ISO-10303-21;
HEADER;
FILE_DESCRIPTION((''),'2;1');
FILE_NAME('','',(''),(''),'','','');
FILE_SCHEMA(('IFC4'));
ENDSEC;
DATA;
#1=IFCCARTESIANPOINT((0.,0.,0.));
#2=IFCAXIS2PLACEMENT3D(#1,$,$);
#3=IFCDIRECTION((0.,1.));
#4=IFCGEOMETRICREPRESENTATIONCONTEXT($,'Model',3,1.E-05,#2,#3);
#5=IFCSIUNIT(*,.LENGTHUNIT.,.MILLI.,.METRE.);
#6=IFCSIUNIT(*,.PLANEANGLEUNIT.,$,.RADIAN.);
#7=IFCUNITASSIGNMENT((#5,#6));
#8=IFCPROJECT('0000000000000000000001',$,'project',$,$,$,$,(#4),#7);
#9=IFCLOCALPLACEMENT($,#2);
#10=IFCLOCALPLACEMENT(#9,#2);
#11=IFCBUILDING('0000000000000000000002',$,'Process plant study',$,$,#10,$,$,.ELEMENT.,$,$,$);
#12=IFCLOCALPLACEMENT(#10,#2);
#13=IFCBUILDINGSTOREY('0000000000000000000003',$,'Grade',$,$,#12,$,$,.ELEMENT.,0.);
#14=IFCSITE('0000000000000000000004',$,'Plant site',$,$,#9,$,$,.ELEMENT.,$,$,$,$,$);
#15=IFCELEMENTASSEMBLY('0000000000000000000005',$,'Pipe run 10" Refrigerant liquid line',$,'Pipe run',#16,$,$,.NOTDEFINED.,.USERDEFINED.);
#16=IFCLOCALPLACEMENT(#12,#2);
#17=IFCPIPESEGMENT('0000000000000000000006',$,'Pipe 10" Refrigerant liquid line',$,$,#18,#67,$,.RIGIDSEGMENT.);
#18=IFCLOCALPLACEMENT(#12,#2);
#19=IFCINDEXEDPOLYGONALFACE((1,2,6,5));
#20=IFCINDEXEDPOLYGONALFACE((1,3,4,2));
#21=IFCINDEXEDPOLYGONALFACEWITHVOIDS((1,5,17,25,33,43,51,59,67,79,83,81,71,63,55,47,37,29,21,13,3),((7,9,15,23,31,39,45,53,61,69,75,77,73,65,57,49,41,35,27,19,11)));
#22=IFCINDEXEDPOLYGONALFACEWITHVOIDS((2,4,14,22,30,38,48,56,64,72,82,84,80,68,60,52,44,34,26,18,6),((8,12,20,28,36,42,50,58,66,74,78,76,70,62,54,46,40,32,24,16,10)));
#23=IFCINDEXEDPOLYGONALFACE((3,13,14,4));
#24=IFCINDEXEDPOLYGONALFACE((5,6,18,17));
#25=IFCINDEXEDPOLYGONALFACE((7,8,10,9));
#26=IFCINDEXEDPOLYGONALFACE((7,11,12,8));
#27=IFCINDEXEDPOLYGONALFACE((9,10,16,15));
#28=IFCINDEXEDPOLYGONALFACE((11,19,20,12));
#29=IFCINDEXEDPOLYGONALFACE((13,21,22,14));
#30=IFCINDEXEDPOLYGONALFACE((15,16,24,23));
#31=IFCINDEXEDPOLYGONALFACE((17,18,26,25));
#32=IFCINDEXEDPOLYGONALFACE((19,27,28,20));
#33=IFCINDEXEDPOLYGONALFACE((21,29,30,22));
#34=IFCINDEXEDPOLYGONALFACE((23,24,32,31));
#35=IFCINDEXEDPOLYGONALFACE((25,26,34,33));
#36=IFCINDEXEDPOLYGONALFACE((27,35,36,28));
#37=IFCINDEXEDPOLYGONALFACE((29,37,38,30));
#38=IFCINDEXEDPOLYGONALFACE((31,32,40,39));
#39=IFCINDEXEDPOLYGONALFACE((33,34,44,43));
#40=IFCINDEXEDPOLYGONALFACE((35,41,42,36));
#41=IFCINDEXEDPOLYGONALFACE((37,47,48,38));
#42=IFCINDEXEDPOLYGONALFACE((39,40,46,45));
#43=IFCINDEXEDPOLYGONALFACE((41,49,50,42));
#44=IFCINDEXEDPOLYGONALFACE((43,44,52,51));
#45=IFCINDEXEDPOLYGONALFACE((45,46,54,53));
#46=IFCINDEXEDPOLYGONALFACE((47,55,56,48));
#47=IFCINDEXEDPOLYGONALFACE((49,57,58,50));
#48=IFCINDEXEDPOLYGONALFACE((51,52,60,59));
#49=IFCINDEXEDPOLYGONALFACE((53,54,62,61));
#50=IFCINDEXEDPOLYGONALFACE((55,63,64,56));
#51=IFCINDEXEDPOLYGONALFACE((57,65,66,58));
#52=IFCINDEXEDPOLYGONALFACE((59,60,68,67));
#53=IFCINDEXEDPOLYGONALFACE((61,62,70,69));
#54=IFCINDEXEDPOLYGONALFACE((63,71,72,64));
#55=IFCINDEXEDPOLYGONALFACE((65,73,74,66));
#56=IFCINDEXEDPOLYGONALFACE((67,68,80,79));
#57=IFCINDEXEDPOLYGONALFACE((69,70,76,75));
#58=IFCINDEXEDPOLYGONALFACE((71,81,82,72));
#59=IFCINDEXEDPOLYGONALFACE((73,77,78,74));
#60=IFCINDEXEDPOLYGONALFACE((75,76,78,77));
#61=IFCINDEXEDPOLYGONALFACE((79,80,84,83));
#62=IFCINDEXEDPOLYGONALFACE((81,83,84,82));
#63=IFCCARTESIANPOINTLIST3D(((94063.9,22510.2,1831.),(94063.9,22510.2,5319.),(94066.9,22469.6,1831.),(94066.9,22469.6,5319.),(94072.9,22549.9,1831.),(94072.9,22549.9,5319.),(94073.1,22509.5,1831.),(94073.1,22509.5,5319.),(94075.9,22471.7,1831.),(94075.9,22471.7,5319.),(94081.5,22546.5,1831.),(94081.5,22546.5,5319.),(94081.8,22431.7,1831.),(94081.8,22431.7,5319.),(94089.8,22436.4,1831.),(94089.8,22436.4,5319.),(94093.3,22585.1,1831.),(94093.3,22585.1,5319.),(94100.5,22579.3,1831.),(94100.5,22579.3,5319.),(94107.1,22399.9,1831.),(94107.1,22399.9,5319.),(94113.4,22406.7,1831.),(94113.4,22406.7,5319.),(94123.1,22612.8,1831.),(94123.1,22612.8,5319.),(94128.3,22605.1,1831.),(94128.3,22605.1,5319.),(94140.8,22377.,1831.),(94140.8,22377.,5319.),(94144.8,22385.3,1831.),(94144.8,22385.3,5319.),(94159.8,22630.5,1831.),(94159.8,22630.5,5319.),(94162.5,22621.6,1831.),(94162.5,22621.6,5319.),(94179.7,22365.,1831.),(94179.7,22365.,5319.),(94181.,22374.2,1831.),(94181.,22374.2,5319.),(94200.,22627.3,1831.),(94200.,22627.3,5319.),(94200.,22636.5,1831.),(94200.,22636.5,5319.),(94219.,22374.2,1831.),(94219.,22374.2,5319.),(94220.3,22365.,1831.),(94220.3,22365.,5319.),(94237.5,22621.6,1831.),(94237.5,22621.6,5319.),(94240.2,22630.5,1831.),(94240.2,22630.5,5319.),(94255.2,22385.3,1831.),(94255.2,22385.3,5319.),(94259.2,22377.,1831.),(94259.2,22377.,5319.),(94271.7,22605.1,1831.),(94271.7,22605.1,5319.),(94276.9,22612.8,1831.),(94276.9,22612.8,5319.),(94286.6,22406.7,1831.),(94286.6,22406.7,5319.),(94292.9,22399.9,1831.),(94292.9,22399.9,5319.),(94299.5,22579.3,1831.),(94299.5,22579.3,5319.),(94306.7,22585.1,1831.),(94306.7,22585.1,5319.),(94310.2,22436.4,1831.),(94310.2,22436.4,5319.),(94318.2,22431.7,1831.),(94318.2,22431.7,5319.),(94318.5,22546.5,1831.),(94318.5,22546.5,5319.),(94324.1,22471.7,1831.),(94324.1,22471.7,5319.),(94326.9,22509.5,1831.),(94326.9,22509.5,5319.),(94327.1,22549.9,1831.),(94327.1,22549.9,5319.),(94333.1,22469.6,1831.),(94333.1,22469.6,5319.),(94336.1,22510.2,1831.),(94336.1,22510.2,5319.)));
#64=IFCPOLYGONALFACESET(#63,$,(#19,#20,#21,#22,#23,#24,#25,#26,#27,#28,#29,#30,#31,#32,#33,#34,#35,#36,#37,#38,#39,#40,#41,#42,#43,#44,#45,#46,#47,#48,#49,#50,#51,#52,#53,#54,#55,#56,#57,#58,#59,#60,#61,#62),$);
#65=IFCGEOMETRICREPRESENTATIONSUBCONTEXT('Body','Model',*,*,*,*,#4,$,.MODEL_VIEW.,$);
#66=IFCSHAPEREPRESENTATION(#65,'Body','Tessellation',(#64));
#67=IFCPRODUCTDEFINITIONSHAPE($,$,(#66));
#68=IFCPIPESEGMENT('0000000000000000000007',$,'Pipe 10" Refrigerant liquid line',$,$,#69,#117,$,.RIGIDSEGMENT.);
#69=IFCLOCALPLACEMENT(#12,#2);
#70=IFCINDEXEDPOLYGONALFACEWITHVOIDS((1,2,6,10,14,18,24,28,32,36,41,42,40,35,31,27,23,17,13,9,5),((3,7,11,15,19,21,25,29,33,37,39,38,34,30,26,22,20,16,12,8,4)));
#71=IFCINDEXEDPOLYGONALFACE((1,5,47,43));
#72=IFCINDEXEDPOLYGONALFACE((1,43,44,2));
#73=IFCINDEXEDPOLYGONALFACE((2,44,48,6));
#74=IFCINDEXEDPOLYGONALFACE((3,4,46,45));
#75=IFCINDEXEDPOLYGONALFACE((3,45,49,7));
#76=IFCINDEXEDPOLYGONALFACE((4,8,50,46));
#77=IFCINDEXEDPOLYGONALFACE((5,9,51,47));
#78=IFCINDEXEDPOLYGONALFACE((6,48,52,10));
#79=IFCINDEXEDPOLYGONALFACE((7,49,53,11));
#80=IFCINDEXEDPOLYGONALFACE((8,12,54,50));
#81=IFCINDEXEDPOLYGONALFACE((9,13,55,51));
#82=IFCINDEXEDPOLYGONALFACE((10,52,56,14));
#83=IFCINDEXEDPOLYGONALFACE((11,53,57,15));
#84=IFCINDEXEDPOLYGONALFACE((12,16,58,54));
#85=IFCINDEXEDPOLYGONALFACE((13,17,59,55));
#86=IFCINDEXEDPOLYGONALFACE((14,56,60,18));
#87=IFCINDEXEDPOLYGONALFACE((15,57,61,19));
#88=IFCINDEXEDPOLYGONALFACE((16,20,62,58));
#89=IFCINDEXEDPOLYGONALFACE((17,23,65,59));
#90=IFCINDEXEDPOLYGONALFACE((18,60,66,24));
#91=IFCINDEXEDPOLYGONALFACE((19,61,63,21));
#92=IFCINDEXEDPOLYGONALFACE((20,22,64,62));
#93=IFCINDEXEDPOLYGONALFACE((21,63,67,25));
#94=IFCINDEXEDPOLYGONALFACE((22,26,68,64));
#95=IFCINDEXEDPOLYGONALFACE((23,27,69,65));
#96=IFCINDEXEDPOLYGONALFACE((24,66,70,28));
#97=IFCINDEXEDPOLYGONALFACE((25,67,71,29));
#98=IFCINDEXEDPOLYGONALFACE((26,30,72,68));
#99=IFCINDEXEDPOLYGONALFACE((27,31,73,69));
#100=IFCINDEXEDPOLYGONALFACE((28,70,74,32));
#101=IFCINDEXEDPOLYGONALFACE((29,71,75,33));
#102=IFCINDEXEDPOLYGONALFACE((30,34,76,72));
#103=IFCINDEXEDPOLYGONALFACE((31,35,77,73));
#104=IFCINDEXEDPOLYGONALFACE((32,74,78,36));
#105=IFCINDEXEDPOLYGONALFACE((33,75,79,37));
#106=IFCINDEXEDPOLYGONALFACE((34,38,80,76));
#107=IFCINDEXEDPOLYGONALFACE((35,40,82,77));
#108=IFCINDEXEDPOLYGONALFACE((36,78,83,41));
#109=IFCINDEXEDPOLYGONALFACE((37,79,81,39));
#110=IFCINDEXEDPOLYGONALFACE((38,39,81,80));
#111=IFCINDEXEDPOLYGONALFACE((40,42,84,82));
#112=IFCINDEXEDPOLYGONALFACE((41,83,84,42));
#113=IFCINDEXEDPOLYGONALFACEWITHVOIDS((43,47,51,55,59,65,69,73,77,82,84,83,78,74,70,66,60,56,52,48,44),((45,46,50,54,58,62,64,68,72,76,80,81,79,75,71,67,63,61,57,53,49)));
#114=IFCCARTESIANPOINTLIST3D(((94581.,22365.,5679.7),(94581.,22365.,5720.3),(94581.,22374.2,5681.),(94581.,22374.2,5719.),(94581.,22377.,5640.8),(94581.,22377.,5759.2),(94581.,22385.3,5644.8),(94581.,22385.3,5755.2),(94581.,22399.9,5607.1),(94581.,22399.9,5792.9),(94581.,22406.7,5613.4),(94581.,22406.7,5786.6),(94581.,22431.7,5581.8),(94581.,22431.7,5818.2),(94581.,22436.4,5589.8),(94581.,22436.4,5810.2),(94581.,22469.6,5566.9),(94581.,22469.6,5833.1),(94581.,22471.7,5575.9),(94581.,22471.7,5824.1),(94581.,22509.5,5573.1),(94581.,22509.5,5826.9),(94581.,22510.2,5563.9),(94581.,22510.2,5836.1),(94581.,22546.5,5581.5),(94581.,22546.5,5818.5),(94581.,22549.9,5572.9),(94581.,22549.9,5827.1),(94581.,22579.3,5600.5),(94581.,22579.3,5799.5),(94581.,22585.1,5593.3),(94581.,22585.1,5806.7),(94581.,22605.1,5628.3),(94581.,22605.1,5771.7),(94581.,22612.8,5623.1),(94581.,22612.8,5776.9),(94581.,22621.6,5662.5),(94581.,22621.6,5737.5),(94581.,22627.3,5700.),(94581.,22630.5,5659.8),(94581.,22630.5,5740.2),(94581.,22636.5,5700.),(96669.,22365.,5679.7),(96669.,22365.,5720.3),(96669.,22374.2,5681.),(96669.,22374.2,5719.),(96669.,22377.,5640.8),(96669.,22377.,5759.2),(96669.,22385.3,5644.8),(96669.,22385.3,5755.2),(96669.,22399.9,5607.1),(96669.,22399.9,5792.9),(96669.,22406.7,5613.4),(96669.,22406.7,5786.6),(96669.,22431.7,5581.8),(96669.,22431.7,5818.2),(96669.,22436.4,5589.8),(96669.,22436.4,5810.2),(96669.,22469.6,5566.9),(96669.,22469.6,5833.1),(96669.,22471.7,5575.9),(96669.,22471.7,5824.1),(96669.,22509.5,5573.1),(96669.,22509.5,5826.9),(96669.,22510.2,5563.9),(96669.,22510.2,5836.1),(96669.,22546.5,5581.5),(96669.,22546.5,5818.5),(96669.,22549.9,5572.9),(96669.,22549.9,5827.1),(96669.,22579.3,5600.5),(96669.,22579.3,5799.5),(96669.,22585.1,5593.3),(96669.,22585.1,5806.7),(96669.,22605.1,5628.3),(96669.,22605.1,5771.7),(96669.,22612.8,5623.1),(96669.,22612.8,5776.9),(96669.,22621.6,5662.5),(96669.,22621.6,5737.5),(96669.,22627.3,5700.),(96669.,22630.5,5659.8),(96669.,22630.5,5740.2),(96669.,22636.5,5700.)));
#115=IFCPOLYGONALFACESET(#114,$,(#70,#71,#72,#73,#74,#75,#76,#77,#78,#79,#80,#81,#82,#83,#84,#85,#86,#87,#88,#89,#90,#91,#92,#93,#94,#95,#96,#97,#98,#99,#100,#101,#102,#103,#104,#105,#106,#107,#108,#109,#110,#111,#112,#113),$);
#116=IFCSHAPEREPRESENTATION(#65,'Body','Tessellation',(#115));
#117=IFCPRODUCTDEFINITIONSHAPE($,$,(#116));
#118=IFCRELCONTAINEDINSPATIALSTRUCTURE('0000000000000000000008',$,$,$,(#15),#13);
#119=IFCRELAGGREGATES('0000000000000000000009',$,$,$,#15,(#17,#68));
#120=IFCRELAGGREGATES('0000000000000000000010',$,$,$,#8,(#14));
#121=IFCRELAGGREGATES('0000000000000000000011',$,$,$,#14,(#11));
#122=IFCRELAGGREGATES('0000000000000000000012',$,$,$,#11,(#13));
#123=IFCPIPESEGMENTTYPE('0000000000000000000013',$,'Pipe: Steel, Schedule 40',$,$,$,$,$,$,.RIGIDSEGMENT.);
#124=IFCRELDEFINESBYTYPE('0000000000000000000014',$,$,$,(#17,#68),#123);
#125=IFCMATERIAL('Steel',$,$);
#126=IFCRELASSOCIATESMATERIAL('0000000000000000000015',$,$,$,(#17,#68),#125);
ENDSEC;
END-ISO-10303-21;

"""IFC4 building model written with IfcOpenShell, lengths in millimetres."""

from ifc_helpers import new_model, si_unit, direction, frame, origin, origin_with_axes, origin_2d, place, context, subcontext, project, spatial, hollow_circle, extrude, material, type_object, element, aggregate, save


model = new_model("IFC4")

# Units and contexts
model_context = context("Model", 3, precision=1e-05, world=origin(), true_north=direction((0.0, 1.0)))
body_context = subcontext(model_context, "Body", "Model", "MODEL_VIEW")
ifc_project = project(units=[si_unit("LENGTHUNIT", "METRE", prefix="MILLI"), si_unit("PLANEANGLEUNIT", "RADIAN")], contexts=[model_context])

# Site, building, storey
site_placement = place(None, origin())
site = spatial("IfcSite", under=ifc_project, at=site_placement, Name="Plant site", CompositionType="ELEMENT")
building_placement = place(site_placement, origin())
building = spatial("IfcBuilding", under=site, at=building_placement, Name="Process plant study", CompositionType="ELEMENT")
storey_placement = place(building_placement, origin())
storey = spatial("IfcBuildingStorey", under=building, at=storey_placement, Name="Grade", CompositionType="ELEMENT", Elevation=0.0)

# Element assembly, pipe segments
ifc_material = material(Name="Steel")
pipe_segment_type = type_object("IfcPipeSegmentType", Name="Pipe: Steel, Schedule 40", PredefinedType="RIGIDSEGMENT")
assembly_1_placement = place(storey_placement, origin_with_axes())
assembly_1 = element("IfcElementAssembly", 1, at=assembly_1_placement, inside=storey, Name="Pipe run 10\" Refrigerant liquid line", ObjectType="Pipe run", AssemblyPlace="NOTDEFINED", PredefinedType="USERDEFINED")
pipe_segment_1_placement = place(storey_placement, origin_with_axes())
pipe_segment_1 = element("IfcPipeSegment", 2, at=pipe_segment_1_placement, type_object=pipe_segment_type, material=ifc_material, Name="Pipe 10\" Refrigerant liquid line", PredefinedType="RIGIDSEGMENT", context=body_context, shape_type="SweptSolid", body=[
    extrude(hollow_circle(Radius=136.5, WallThickness=9.3, at=origin_2d()), frame((94200.0, 22500.0, 1831.0), z_axis=(0.0, 0.0, 1.0), x_axis=(0.0, 1.0, 0.0)), (0.0, 0.0, 1.0), 3488.0),
])
pipe_segment_2_placement = place(storey_placement, origin_with_axes())
pipe_segment_2 = element("IfcPipeSegment", 3, at=pipe_segment_2_placement, type_object=pipe_segment_type, material=ifc_material, Name="Pipe 10\" Refrigerant liquid line", PredefinedType="RIGIDSEGMENT", context=body_context, shape_type="SweptSolid", body=[
    extrude(hollow_circle(Radius=136.5, WallThickness=9.3, at=origin_2d()), frame((94581.0, 22500.0, 5700.0), z_axis=(1.0, 0.0, 0.0), x_axis=(0.0, 1.0, 0.0)), (0.0, 0.0, 1.0), 2088.0),
])

aggregate(assembly_1, [pipe_segment_1, pipe_segment_2])

save(model, "model.ifc")
